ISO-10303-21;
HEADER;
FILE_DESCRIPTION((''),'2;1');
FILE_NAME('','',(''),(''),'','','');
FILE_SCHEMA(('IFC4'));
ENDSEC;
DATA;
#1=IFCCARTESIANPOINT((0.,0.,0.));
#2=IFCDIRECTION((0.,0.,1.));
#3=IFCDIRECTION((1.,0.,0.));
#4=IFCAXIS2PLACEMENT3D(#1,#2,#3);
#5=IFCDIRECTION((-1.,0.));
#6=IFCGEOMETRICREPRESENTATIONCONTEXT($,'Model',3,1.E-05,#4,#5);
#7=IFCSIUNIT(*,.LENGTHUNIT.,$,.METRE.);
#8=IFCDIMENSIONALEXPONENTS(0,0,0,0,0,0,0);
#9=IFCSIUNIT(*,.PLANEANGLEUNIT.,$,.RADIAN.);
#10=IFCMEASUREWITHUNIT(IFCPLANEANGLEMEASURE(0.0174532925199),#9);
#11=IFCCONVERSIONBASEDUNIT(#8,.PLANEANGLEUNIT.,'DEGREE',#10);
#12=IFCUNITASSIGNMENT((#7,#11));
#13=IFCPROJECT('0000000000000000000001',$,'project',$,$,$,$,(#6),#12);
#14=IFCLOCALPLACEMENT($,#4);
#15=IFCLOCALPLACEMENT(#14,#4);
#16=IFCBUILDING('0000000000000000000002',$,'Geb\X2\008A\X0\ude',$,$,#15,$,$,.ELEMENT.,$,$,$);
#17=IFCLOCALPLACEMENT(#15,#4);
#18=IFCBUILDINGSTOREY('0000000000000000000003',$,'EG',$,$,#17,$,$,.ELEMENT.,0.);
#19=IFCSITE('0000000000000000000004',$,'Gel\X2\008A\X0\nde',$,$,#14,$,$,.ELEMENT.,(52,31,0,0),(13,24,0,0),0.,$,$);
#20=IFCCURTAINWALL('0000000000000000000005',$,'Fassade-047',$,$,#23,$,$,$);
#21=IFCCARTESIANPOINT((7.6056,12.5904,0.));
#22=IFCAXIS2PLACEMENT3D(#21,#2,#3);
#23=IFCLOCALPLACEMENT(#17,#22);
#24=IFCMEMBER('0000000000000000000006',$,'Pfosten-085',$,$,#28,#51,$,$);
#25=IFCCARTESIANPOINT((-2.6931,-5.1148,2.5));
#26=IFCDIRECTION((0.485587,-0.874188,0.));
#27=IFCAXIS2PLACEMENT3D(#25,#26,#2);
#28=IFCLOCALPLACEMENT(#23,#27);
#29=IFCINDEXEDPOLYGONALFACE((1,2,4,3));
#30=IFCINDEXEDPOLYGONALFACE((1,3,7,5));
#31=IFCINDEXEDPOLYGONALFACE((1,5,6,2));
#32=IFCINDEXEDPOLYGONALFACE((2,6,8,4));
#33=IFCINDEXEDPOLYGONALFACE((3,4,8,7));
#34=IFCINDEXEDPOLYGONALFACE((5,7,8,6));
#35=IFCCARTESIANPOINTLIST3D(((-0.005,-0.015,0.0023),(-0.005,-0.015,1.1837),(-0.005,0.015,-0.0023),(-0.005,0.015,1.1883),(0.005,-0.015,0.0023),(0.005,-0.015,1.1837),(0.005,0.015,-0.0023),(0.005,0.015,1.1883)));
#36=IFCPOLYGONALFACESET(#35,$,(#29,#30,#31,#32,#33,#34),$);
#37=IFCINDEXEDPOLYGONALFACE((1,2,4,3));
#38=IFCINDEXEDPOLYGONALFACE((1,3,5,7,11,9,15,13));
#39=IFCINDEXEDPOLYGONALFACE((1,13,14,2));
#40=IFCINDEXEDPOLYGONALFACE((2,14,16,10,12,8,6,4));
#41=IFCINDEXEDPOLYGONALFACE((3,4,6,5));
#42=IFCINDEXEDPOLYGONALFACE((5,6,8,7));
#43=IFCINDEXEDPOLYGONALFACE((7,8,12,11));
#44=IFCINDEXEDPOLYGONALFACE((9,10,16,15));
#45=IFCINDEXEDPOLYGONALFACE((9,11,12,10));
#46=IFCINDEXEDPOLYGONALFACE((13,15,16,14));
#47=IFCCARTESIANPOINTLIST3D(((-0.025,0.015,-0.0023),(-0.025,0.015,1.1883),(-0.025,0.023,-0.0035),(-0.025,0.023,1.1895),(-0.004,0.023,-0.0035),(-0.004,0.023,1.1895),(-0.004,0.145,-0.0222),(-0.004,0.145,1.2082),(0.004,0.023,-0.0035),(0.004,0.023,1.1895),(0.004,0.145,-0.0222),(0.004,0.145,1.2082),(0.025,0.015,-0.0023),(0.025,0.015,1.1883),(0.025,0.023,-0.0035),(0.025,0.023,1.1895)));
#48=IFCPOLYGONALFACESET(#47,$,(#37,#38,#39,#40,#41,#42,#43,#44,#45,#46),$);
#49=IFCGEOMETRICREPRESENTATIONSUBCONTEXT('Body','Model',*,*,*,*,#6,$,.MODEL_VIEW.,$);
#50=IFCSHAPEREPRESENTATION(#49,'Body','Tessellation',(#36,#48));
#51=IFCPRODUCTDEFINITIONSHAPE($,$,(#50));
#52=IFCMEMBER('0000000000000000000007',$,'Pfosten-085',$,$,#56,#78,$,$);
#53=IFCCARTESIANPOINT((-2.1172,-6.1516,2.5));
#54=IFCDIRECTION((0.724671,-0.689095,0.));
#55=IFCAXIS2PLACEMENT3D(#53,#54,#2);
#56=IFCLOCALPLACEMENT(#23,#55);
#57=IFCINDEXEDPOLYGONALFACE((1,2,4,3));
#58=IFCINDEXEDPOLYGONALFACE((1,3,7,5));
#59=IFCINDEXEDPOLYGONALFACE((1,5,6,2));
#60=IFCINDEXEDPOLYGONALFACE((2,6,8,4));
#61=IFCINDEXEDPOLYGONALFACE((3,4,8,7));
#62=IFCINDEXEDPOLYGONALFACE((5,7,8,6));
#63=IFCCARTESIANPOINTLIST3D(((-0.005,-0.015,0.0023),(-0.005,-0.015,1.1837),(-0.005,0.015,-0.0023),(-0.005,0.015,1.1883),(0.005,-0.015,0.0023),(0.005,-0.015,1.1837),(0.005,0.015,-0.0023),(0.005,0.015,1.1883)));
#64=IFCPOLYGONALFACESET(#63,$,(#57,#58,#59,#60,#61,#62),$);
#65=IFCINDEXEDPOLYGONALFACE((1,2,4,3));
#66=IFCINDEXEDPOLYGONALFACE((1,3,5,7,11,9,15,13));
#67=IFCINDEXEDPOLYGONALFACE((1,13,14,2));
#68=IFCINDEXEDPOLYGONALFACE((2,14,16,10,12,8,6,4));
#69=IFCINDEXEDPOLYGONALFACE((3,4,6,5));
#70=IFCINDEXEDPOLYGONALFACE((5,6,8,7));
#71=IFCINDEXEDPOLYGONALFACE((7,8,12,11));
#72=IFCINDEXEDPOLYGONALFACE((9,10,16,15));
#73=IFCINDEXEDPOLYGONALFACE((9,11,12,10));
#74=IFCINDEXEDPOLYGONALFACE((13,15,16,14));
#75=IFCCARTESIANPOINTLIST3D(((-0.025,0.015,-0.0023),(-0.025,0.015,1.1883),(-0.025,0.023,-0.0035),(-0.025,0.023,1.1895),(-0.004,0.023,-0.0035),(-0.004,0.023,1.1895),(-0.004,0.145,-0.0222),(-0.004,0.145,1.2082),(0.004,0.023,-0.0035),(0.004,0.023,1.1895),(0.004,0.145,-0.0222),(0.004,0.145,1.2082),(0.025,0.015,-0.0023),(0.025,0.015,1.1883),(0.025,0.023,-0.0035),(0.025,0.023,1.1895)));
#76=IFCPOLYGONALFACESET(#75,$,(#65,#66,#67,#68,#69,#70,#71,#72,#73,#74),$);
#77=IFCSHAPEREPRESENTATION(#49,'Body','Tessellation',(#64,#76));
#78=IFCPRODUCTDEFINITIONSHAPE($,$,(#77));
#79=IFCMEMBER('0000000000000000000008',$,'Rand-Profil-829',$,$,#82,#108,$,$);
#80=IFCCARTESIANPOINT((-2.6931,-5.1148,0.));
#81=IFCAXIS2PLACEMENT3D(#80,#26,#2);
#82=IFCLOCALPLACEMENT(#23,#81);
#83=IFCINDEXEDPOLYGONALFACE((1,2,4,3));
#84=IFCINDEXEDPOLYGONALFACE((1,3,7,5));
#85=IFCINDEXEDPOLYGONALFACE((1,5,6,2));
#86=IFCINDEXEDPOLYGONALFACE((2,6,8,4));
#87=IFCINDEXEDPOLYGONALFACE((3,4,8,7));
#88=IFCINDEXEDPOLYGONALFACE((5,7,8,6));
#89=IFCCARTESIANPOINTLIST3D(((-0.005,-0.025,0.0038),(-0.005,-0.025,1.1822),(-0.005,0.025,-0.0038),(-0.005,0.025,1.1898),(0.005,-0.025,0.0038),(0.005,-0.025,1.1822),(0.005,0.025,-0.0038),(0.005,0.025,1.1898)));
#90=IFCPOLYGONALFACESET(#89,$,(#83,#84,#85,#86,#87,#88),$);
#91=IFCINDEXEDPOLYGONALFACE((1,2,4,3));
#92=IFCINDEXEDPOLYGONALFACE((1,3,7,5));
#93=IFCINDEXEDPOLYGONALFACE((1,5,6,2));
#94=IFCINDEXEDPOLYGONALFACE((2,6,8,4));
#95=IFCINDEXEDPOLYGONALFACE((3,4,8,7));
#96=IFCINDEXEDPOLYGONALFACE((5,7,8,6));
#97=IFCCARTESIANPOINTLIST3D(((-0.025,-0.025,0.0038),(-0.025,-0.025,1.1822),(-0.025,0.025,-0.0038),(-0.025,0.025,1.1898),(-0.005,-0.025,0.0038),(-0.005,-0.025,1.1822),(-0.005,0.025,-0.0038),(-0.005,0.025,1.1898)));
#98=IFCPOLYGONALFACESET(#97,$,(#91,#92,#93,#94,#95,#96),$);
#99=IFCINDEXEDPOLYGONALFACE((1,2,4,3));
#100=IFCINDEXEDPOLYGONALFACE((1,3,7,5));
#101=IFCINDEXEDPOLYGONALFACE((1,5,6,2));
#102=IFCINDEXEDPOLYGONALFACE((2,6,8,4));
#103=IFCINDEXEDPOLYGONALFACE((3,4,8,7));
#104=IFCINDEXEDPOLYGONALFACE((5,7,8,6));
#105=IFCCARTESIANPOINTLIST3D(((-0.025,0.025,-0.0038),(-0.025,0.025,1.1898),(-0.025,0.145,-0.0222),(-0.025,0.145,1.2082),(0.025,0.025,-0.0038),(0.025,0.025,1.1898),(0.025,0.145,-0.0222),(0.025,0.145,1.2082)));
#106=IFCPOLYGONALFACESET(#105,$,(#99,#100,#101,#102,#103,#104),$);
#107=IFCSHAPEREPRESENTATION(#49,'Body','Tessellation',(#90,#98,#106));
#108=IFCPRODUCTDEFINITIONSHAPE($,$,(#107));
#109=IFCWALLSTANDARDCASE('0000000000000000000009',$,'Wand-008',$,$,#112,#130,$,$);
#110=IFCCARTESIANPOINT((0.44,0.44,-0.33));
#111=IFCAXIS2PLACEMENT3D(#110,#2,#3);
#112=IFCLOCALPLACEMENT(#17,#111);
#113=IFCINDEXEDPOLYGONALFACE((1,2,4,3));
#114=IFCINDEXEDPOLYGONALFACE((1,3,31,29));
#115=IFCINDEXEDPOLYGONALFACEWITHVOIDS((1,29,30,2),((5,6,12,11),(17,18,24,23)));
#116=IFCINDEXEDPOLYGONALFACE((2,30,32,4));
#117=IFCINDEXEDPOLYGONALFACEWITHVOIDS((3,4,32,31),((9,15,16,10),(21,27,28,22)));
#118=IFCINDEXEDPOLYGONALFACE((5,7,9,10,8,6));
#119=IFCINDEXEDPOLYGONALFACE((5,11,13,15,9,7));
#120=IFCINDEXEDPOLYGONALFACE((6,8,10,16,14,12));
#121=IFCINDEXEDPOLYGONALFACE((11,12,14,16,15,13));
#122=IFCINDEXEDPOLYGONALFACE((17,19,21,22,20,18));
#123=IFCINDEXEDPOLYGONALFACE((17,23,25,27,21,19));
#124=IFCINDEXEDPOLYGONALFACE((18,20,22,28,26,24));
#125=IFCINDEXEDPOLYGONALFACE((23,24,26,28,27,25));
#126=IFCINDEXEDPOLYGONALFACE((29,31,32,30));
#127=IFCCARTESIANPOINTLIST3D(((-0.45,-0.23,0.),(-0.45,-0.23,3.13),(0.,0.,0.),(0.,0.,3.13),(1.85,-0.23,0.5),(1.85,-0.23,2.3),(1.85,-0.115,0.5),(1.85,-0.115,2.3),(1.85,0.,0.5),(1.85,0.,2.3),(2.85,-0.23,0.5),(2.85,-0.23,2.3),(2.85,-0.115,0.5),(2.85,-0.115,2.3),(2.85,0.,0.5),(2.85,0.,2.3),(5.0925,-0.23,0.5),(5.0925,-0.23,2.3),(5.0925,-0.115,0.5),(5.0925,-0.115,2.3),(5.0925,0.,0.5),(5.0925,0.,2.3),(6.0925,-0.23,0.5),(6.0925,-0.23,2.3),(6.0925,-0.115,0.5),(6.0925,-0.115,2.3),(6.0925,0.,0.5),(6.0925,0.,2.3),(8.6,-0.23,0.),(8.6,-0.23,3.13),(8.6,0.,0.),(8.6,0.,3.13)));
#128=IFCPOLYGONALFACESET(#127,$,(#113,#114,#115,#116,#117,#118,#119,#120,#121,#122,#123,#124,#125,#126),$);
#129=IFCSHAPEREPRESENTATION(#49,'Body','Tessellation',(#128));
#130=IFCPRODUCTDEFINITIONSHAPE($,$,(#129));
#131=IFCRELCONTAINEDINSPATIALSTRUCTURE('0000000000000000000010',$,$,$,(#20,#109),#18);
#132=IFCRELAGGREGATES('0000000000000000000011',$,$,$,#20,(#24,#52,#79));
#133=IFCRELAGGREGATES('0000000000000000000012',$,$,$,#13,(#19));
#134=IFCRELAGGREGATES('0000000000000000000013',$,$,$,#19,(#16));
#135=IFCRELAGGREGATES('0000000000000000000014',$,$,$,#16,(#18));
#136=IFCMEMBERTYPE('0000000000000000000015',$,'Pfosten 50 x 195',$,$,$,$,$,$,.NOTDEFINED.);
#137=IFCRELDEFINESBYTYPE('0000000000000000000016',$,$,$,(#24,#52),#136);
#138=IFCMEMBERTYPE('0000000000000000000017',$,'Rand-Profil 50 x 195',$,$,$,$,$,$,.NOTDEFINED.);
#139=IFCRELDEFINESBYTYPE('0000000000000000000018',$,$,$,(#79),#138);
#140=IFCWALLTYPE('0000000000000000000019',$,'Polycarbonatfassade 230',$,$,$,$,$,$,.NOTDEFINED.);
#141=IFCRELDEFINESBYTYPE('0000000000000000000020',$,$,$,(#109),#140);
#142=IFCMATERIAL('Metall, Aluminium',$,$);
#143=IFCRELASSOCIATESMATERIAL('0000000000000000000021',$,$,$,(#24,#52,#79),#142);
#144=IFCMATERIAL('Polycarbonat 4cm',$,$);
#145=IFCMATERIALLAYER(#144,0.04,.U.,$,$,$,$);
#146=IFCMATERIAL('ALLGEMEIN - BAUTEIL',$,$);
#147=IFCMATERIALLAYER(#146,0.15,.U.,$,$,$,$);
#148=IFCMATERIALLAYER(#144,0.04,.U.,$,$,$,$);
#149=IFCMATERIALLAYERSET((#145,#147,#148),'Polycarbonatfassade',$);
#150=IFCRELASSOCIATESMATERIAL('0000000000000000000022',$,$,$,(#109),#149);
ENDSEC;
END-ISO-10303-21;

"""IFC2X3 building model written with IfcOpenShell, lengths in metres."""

from ifc_helpers import new_model, entity, si_unit, converted_unit, direction, frame, origin_with_axes, origin_2d_with_axis, place, context, subcontext, project, spatial, polyline, rectangle, outline, extrude, clip, halfspace, material, layer, layer_set, layer_usage, type_object, element, aggregate, save


model = new_model("IFC2X3")

# Units and contexts
model_context = context("Model", 3, precision=1e-05, world=origin_with_axes(), true_north=direction((-1.0, 0.0)))
body_context = subcontext(model_context, "Body", "Model", "MODEL_VIEW")
ifc_project = project(units=[si_unit("LENGTHUNIT", "METRE"), converted_unit("PLANEANGLEUNIT", "DEGREE", entity("IfcPlaneAngleMeasure", 0.0174532925199), si_unit("PLANEANGLEUNIT", "RADIAN"), dimensions=[0, 0, 0, 0, 0, 0, 0])], contexts=[model_context])

# Site, building, storey
site_placement = place(None, origin_with_axes())
site = spatial("IfcSite", under=ifc_project, at=site_placement, Name="Gel\u008ande", CompositionType="ELEMENT", RefLatitude=(52, 31, 0, 0), RefLongitude=(13, 24, 0, 0), RefElevation=0.0)
building_placement = place(site_placement, origin_with_axes())
building = spatial("IfcBuilding", under=site, at=building_placement, Name="Geb\u008aude", CompositionType="ELEMENT")
storey_placement = place(building_placement, origin_with_axes())
storey = spatial("IfcBuildingStorey", under=building, at=storey_placement, Name="EG", CompositionType="ELEMENT", Elevation=0.0)

# Curtain wall, members
curtain_wall_placement = place(storey_placement, frame((7.6056, 12.5904, 0.0), z_axis=(0.0, 0.0, 1.0), x_axis=(1.0, 0.0, 0.0)))
curtain_wall = element("IfcCurtainWall", 1, at=curtain_wall_placement, inside=storey, Name="Fassade-047")
ifc_material_1 = material(Name="Metall, Aluminium")
member_type_1 = type_object("IfcMemberType", Name="Pfosten 50 x 195", PredefinedType="NOTDEFINED")
member_1_placement = place(curtain_wall_placement, frame((-2.6931, -5.1148, 2.5), z_axis=(0.485587, -0.874188, 0.0), x_axis=(0.0, 0.0, 1.0)))
member_1 = element("IfcMember", 2, at=member_1_placement, type_object=member_type_1, material=ifc_material_1, Name="Pfosten-085", context=body_context, shape_type="Clipping", body=[
    clip(clip(extrude(outline(polyline([(0.015, -0.005), (0.015, 0.005), (-0.015, 0.005), (-0.015, -0.005), (0.015, -0.005)])), frame((0.0, 0.0, -0.0023), z_axis=(0.0, 0.0, 1.0), x_axis=(0.0, 1.0, 0.0)), (0.0, 0.0, 1.0), 1.1906), halfspace(frame((0.0, -0.1772, 1.1589), z_axis=(0.0, 0.151179, -0.988506), x_axis=(0.0, -0.988506, -0.151179)), True)), halfspace(frame((0.0, 0.0, 0.0), z_axis=(0.0, 0.151179, 0.988506), x_axis=(0.0, 0.988506, -0.151179)), True)),
    clip(clip(extrude(outline(polyline([(0.145, -0.004), (0.145, 0.004), (0.023, 0.004), (0.023, 0.025), (0.015, 0.025), (0.015, -0.025), (0.023, -0.025), (0.023, -0.004), (0.145, -0.004)])), frame((0.0, 0.0, -0.0222), z_axis=(0.0, 0.0, 1.0), x_axis=(0.0, 1.0, 0.0)), (0.0, 0.0, 1.0), 1.2304), halfspace(frame((0.0, -0.1772, 1.1589), z_axis=(0.0, 0.151179, -0.988506), x_axis=(0.0, -0.988506, -0.151179)), True)), halfspace(frame((0.0, 0.0, 0.0), z_axis=(0.0, 0.151179, 0.988506), x_axis=(0.0, 0.988506, -0.151179)), True)),
])
member_2_placement = place(curtain_wall_placement, frame((-2.1172, -6.1516, 2.5), z_axis=(0.724671, -0.689095, 0.0), x_axis=(0.0, 0.0, 1.0)))
member_2 = element("IfcMember", 3, at=member_2_placement, type_object=member_type_1, material=ifc_material_1, Name="Pfosten-085", context=body_context, shape_type="Clipping", body=[
    clip(clip(extrude(outline(polyline([(0.015, -0.005), (0.015, 0.005), (-0.015, 0.005), (-0.015, -0.005), (0.015, -0.005)])), frame((0.0, 0.0, -0.0023), z_axis=(0.0, 0.0, 1.0), x_axis=(0.0, 1.0, 0.0)), (0.0, 0.0, 1.0), 1.1906), halfspace(frame((0.0, -0.1772, 1.1589), z_axis=(0.0, 0.151179, -0.988506), x_axis=(0.0, -0.988506, -0.151179)), True)), halfspace(frame((0.0, 0.0, 0.0), z_axis=(0.0, 0.151179, 0.988506), x_axis=(0.0, 0.988506, -0.151179)), True)),
    clip(clip(extrude(outline(polyline([(0.145, -0.004), (0.145, 0.004), (0.023, 0.004), (0.023, 0.025), (0.015, 0.025), (0.015, -0.025), (0.023, -0.025), (0.023, -0.004), (0.145, -0.004)])), frame((0.0, 0.0, -0.0222), z_axis=(0.0, 0.0, 1.0), x_axis=(0.0, 1.0, 0.0)), (0.0, 0.0, 1.0), 1.2304), halfspace(frame((0.0, -0.1772, 1.1589), z_axis=(0.0, 0.151179, -0.988506), x_axis=(0.0, -0.988506, -0.151179)), True)), halfspace(frame((0.0, 0.0, 0.0), z_axis=(0.0, 0.151179, 0.988506), x_axis=(0.0, 0.988506, -0.151179)), True)),
])
member_type_2 = type_object("IfcMemberType", Name="Rand-Profil 50 x 195", PredefinedType="NOTDEFINED")
member_3_placement = place(curtain_wall_placement, frame((-2.6931, -5.1148, 0.0), z_axis=(0.485587, -0.874188, 0.0), x_axis=(0.0, 0.0, 1.0)))
member_3 = element("IfcMember", 4, at=member_3_placement, type_object=member_type_2, material=ifc_material_1, Name="Rand-Profil-829", context=body_context, shape_type="Clipping", body=[
    clip(clip(extrude(outline(polyline([(0.025, -0.005), (0.025, 0.005), (-0.025, 0.005), (-0.025, -0.005), (0.025, -0.005)])), frame((0.0, 0.0, -0.0038), z_axis=(0.0, 0.0, 1.0), x_axis=(0.0, 1.0, 0.0)), (0.0, 0.0, 1.0), 1.1936), halfspace(frame((0.0, -0.1772, 1.1589), z_axis=(0.0, 0.151179, -0.988506), x_axis=(0.0, -0.988506, -0.151179)), True)), halfspace(frame((0.0, 0.0, 0.0), z_axis=(0.0, 0.151179, 0.988506), x_axis=(0.0, 0.988506, -0.151179)), True)),
    clip(clip(extrude(outline(polyline([(0.025, 0.005), (0.025, 0.025), (-0.025, 0.025), (-0.025, 0.005), (0.025, 0.005)])), frame((0.0, 0.0, -0.0038), z_axis=(0.0, 0.0, 1.0), x_axis=(0.0, 1.0, 0.0)), (0.0, 0.0, 1.0), 1.1936), halfspace(frame((0.0, -0.1772, 1.1589), z_axis=(0.0, 0.151179, -0.988506), x_axis=(0.0, -0.988506, -0.151179)), True)), halfspace(frame((0.0, 0.0, 0.0), z_axis=(0.0, 0.151179, 0.988506), x_axis=(0.0, 0.988506, -0.151179)), True)),
    clip(clip(extrude(outline(polyline([(0.145, -0.025), (0.145, 0.025), (0.025, 0.025), (0.025, -0.025), (0.145, -0.025)])), frame((0.0, 0.0, -0.0222), z_axis=(0.0, 0.0, 1.0), x_axis=(0.0, 1.0, 0.0)), (0.0, 0.0, 1.0), 1.2304), halfspace(frame((0.0, -0.1772, 1.1589), z_axis=(0.0, 0.151179, -0.988506), x_axis=(0.0, -0.988506, -0.151179)), True)), halfspace(frame((0.0, 0.0, 0.0), z_axis=(0.0, 0.151179, 0.988506), x_axis=(0.0, 0.988506, -0.151179)), True)),
])

# Shared definitions
ifc_material_2 = material(Name="ALLGEMEIN - BAUTEIL")

aggregate(curtain_wall, [member_1, member_2, member_3])

# Wall, openings
ifc_material_3 = material(Name="Polycarbonat 4cm")
ifc_layer_1 = layer(ifc_material_3, 0.04, ventilated="UNKNOWN")
ifc_layer_2 = layer(ifc_material_2, 0.15, ventilated="UNKNOWN")
ifc_layer_3 = layer(ifc_material_3, 0.04, ventilated="UNKNOWN")
ifc_layer_set_1 = layer_set([ifc_layer_1, ifc_layer_2, ifc_layer_3], Name="Polycarbonatfassade")
ifc_layer_usage_1 = layer_usage(ifc_layer_set_1, "AXIS2", "NEGATIVE", 0.0)
wall_type_1 = type_object("IfcWallType", Name="Polycarbonatfassade 230", PredefinedType="NOTDEFINED")
wall_1_placement = place(storey_placement, frame((0.44, 0.44, -0.33), z_axis=(0.0, 0.0, 1.0), x_axis=(1.0, 0.0, 0.0)))
wall_1 = element("IfcWallStandardCase", 5, at=wall_1_placement, inside=storey, type_object=wall_type_1, material=ifc_layer_usage_1, Name="Wand-008", context=body_context, shape_type="SweptSolid", body=[
    extrude(outline(polyline([(-0.45, -0.23), (8.6, -0.23), (8.6, 0.0), (0.0, 0.0), (-0.45, -0.23)])), origin_with_axes(), (0.0, 0.0, 1.0), 3.13),
])
opening_1_placement = place(wall_1_placement, frame((5.5925, 0.0, 0.5), z_axis=(0.0, 0.0, 1.0), x_axis=(1.0, 0.0, 0.0)))
element("IfcOpeningElement", 6, at=opening_1_placement, cuts=wall_1, context=body_context, shape_type="SweptSolid", body=[
    extrude(rectangle(XDim=1.0, YDim=1.8, at=origin_2d_with_axis()), frame((0.0, 0.23, 0.9), z_axis=(0.0, 1.0, 0.0), x_axis=(-1.0, 0.0, 0.0)), (0.0, 0.0, -1.0), 0.345),
    extrude(rectangle(XDim=1.0, YDim=1.8, at=origin_2d_with_axis()), frame((0.0, -0.46, 0.9), z_axis=(0.0, -1.0, 0.0), x_axis=(-1.0, 0.0, 0.0)), (0.0, 0.0, -1.0), 0.345),
])
opening_2_placement = place(wall_1_placement, frame((2.35, 0.0, 0.5), z_axis=(0.0, 0.0, 1.0), x_axis=(1.0, 0.0, 0.0)))
element("IfcOpeningElement", 7, at=opening_2_placement, cuts=wall_1, context=body_context, shape_type="SweptSolid", body=[
    extrude(rectangle(XDim=1.0, YDim=1.8, at=origin_2d_with_axis()), frame((0.0, 0.23, 0.9), z_axis=(0.0, 1.0, 0.0), x_axis=(-1.0, 0.0, 0.0)), (0.0, 0.0, -1.0), 0.345),
    extrude(rectangle(XDim=1.0, YDim=1.8, at=origin_2d_with_axis()), frame((0.0, -0.46, 0.9), z_axis=(0.0, -1.0, 0.0), x_axis=(-1.0, 0.0, 0.0)), (0.0, 0.0, -1.0), 0.345),
])

save(model, "model.ifc")
